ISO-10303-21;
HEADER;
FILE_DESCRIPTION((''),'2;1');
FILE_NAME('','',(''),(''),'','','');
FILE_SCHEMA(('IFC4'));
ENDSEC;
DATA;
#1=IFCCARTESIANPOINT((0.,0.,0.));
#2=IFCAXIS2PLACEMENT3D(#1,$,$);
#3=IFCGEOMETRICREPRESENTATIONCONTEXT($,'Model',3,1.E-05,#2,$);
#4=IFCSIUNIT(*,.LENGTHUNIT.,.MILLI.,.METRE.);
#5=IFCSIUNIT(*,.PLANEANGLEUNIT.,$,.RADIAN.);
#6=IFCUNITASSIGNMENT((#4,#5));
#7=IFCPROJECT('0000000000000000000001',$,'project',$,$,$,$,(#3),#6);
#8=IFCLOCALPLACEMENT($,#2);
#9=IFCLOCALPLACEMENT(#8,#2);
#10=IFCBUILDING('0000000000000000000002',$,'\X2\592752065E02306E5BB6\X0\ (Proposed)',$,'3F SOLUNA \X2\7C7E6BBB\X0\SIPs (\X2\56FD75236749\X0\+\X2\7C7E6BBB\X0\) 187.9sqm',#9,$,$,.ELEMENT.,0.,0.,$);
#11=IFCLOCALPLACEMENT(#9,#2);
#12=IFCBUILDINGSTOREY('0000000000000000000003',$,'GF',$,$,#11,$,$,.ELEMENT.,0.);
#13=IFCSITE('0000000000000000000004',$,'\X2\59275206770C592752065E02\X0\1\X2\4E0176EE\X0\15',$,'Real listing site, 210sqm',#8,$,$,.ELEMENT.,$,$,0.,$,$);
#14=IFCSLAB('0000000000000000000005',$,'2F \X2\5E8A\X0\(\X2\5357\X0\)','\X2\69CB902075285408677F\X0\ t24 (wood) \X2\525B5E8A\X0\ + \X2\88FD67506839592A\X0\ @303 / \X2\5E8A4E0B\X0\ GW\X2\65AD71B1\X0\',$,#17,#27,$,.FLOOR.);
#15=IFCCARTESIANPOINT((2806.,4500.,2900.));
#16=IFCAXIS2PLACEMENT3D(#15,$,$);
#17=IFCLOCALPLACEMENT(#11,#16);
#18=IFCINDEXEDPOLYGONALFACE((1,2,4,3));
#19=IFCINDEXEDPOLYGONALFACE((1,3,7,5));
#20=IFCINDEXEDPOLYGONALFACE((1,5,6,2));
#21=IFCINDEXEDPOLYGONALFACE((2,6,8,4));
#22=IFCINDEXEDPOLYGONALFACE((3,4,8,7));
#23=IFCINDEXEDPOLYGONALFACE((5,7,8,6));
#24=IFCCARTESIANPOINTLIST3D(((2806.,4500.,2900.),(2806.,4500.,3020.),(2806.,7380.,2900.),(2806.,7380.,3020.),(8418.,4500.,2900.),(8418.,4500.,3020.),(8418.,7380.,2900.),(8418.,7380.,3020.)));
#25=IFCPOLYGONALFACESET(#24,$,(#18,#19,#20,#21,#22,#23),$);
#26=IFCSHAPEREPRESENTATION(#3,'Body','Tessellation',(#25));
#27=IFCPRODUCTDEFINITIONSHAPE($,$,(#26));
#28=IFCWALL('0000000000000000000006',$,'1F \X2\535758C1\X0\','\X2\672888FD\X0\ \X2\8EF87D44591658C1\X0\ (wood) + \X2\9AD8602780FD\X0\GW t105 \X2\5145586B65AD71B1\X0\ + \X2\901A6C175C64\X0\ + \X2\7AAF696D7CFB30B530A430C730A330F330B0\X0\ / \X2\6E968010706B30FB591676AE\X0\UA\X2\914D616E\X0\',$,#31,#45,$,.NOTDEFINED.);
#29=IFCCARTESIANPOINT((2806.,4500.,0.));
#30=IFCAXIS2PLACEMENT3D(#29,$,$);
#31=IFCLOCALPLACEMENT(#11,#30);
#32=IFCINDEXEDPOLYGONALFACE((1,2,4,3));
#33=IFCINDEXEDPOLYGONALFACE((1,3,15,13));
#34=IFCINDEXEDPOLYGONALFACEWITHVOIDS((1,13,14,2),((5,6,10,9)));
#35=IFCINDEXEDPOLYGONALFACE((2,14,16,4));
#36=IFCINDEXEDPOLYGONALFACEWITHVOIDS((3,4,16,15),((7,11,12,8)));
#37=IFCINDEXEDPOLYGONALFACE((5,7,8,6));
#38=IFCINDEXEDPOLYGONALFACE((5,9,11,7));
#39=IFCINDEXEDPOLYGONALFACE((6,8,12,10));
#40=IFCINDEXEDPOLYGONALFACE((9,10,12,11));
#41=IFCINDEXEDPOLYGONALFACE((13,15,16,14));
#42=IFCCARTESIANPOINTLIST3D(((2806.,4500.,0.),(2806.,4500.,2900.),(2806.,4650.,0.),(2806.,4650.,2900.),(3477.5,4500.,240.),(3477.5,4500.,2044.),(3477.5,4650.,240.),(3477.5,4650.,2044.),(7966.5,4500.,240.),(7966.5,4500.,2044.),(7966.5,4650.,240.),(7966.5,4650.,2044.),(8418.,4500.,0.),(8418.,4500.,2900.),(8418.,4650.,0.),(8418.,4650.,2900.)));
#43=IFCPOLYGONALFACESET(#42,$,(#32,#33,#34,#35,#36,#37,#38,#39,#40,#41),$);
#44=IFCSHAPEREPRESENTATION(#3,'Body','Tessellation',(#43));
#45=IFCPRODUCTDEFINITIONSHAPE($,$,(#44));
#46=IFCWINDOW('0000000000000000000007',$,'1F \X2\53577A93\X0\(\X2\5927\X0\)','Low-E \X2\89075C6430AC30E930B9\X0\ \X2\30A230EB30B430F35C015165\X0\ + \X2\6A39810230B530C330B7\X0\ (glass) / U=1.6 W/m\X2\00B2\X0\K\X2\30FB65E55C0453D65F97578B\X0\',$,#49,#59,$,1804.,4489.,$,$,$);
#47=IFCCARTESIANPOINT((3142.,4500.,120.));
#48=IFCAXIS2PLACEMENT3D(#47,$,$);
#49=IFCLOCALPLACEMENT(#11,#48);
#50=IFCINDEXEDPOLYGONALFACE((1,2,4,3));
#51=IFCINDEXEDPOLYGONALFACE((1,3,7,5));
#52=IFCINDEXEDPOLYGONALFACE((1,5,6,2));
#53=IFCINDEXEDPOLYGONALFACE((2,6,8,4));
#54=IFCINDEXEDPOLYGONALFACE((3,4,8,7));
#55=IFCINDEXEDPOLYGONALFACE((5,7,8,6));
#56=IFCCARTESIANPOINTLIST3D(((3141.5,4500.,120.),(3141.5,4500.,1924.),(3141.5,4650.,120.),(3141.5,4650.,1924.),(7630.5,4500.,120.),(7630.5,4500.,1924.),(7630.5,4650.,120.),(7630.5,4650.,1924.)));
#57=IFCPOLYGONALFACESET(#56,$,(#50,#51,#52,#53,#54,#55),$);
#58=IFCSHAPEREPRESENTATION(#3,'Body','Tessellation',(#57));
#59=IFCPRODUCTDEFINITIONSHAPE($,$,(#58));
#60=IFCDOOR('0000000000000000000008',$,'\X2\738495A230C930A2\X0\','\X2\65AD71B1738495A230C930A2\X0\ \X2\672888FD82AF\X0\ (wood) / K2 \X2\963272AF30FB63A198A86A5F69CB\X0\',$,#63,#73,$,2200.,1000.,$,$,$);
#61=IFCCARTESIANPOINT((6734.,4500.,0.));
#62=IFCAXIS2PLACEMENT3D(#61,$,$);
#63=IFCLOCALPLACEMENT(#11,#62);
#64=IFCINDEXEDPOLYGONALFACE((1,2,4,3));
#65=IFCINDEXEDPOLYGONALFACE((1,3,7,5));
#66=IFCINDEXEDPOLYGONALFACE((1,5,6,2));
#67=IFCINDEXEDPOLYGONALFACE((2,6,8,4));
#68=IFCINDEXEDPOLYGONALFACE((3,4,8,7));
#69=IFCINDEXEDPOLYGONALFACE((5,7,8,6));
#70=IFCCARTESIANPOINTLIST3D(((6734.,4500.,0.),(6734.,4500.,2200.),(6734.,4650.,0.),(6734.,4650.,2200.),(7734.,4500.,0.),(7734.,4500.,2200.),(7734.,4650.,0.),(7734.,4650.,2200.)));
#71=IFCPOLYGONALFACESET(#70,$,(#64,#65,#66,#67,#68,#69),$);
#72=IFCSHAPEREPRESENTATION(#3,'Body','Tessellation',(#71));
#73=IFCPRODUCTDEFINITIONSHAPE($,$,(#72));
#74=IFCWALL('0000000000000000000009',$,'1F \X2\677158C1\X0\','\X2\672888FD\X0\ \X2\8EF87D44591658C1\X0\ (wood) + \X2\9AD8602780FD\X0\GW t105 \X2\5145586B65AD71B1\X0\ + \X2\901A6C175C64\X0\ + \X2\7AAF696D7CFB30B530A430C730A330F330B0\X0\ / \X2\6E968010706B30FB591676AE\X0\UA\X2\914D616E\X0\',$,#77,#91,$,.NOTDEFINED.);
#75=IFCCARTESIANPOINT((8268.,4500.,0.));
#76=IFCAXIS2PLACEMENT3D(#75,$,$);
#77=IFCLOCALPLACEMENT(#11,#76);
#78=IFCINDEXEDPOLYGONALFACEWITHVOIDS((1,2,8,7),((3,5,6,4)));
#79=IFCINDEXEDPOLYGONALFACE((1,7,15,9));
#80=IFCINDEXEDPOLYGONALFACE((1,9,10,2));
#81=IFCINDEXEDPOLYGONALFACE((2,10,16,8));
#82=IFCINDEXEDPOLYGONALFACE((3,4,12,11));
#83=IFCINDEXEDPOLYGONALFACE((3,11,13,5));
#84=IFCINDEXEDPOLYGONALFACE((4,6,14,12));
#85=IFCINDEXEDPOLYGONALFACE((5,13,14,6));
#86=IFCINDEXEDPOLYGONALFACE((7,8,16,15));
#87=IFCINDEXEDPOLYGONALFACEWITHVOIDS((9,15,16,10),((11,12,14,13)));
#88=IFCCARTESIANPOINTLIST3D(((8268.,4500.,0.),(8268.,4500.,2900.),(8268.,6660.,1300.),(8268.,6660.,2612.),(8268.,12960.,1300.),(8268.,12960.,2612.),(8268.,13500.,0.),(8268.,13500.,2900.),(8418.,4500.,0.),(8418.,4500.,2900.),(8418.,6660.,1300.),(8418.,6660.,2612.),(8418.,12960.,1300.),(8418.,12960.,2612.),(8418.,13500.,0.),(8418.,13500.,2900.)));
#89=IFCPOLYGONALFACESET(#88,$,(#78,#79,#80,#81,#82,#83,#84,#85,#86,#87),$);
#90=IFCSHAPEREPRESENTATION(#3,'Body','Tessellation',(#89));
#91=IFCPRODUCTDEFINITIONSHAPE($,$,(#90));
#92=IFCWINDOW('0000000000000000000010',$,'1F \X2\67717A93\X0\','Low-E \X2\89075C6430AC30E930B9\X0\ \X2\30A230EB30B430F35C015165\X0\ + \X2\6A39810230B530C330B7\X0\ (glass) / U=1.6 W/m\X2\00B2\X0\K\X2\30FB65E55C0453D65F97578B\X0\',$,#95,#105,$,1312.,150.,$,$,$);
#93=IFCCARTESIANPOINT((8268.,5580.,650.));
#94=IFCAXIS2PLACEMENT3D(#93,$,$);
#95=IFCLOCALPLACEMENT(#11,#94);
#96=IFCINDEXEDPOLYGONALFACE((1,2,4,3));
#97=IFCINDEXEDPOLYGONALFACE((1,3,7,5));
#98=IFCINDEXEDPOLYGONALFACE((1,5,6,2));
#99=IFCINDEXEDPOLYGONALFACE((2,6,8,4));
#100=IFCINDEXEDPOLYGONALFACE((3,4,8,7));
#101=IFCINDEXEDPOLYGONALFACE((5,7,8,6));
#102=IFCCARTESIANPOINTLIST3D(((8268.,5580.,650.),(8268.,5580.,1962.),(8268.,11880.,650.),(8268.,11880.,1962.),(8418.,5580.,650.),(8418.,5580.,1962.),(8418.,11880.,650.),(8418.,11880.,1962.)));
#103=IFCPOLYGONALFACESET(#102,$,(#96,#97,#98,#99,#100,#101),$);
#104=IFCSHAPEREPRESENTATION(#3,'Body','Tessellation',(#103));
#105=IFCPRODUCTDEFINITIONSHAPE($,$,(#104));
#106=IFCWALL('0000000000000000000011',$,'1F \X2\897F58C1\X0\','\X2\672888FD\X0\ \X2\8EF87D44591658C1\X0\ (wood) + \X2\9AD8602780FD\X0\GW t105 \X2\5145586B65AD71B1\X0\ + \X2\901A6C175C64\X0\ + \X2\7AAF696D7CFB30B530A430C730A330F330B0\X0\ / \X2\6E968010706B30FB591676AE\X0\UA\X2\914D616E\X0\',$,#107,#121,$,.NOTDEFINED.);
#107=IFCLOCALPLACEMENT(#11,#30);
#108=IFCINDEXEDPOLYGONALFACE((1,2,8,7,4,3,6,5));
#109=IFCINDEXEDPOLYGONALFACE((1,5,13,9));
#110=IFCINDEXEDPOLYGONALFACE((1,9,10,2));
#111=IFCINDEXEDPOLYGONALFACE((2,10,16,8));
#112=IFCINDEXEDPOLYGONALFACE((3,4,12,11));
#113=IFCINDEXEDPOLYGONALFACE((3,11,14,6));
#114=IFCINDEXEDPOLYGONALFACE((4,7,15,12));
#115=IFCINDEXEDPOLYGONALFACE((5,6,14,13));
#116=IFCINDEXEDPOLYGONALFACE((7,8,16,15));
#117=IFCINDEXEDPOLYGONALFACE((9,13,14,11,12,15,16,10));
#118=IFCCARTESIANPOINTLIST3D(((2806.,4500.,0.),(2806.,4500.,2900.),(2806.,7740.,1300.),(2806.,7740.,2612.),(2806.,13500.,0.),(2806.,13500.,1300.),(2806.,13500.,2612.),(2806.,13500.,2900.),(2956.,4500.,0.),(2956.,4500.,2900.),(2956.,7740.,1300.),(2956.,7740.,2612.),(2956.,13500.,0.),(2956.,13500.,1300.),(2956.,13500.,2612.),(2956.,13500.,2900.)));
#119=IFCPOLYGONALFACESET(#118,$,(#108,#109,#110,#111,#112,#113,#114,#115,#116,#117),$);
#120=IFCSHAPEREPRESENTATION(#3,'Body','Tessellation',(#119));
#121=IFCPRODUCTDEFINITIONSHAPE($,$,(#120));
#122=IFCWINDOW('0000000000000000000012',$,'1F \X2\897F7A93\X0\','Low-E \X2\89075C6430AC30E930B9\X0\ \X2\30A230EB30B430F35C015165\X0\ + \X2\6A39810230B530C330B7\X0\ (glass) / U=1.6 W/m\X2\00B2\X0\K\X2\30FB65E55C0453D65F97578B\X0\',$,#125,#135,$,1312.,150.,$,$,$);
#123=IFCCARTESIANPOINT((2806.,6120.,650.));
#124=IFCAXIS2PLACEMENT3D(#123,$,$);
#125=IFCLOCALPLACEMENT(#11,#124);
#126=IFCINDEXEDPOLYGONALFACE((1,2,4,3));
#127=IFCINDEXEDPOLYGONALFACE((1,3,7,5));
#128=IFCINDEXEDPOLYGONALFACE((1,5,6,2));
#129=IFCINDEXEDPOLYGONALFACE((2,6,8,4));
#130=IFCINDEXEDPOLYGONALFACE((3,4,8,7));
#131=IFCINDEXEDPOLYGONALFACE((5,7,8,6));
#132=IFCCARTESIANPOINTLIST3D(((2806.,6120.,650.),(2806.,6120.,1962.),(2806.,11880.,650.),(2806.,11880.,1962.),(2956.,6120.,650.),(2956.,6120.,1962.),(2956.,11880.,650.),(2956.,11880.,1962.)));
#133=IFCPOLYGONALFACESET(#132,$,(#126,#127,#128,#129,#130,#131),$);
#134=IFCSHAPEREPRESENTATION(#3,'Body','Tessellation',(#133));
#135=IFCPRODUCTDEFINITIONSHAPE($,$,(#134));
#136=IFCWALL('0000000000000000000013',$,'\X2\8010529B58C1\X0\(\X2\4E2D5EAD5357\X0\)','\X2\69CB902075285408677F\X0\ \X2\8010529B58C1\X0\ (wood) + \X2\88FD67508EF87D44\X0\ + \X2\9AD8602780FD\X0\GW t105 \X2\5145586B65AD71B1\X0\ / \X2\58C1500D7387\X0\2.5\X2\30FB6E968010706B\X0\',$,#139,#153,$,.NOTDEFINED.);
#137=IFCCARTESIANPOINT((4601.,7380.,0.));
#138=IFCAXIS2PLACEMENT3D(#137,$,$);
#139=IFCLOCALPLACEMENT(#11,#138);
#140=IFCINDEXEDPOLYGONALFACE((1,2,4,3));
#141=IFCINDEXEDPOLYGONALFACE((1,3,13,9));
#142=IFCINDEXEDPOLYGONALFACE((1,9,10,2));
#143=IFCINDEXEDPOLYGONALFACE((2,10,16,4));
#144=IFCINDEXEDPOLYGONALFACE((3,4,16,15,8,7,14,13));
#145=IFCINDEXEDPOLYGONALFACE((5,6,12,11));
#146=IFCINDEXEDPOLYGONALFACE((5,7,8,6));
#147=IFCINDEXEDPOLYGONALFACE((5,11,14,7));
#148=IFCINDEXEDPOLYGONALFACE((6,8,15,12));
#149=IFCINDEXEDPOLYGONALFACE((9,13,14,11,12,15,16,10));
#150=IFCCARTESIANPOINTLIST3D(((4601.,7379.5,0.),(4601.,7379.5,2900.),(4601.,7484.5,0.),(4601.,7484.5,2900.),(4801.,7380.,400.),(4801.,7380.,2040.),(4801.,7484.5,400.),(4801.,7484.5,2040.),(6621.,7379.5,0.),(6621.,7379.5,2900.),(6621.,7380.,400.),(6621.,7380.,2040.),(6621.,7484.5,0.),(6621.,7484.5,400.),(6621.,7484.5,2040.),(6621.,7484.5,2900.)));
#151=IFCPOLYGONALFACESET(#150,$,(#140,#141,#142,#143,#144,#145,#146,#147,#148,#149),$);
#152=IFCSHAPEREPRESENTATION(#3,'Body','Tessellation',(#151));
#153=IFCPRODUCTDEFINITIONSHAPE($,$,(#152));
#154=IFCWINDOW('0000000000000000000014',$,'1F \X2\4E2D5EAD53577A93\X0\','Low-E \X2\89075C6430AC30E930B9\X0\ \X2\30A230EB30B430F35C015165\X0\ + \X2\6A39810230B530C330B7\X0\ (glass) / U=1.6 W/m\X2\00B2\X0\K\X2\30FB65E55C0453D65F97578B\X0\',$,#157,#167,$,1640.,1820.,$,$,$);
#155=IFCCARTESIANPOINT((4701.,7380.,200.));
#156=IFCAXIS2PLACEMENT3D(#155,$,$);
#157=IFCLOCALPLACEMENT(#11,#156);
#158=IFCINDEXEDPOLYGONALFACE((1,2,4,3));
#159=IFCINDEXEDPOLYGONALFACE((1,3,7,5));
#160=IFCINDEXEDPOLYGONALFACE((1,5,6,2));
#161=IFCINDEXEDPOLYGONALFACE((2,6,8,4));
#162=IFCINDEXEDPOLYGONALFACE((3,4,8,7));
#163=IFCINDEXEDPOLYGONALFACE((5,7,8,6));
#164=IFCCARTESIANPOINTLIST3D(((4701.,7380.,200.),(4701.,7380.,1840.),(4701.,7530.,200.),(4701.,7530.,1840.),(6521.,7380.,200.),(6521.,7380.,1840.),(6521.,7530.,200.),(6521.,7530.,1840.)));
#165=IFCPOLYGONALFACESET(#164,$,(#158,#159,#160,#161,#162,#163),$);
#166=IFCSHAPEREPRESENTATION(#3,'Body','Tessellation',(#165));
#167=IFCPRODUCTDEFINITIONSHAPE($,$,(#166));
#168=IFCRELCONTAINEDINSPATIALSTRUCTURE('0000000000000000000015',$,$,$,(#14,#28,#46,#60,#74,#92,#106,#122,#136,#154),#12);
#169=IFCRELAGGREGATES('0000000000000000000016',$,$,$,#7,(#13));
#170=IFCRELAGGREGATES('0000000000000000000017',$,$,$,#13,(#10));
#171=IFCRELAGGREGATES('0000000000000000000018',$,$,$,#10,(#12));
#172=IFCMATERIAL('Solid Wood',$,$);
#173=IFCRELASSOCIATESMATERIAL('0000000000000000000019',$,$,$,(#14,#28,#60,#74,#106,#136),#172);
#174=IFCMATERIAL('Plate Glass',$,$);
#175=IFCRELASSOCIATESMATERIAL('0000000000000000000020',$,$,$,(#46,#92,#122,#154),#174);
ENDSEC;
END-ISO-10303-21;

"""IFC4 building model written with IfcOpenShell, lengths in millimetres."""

from ifc_helpers import new_model, si_unit, frame, frame_2d, origin, place, context, project, spatial, rectangle, extrude, material, element, fill, save


model = new_model("IFC4")

# Units and contexts
model_context = context("Model", 3, precision=1e-05, world=origin())
ifc_project = project(units=[si_unit("LENGTHUNIT", "METRE", prefix="MILLI"), si_unit("PLANEANGLEUNIT", "RADIAN")], contexts=[model_context])

# Site, building, storey
site_placement = place(None, origin())
site = spatial("IfcSite", under=ifc_project, at=site_placement, Name="大分県大分市1丁目15", ObjectType="Real listing site, 210sqm", CompositionType="ELEMENT", RefElevation=0.0)
building_placement = place(site_placement, origin())
building = spatial("IfcBuilding", under=site, at=building_placement, Name="大分市の家 (Proposed)", ObjectType="3F SOLUNA 籾殻SIPs (国産杉+籾殻) 187.9sqm", CompositionType="ELEMENT", ElevationOfRefHeight=0.0, ElevationOfTerrain=0.0)
storey_placement = place(building_placement, origin())
storey = spatial("IfcBuildingStorey", under=building, at=storey_placement, Name="GF", CompositionType="ELEMENT", Elevation=0.0)

# Slab
ifc_material_1 = material(Name="Solid Wood")
slab_1_placement = place(storey_placement, frame((2806.0, 4500.0, 2900.0)))
element("IfcSlab", 1, at=slab_1_placement, inside=storey, material=ifc_material_1, Name="2F 床(南)", Description="構造用合板 t24 (wood) 剛床 + 製材根太 @303 / 床下 GW断熱", PredefinedType="FLOOR", context=model_context, shape_type="SweptSolid", body=[
    extrude(rectangle(XDim=5612.0, YDim=2880.0, at=frame_2d((2806.0, 1440.0))), frame((2806.0, 4500.0, 2900.0)), (0.0, 0.0, 1.0), 120.0),
])

# Wall, openings, window, door
wall_1_placement = place(storey_placement, frame((2806.0, 4500.0, 0.0)))
wall_1 = element("IfcWall", 2, at=wall_1_placement, inside=storey, material=ifc_material_1, Name="1F 南壁", Description="木製 軸組外壁 (wood) + 高性能GW t105 充填断熱 + 通気層 + 窯業系サイディング / 準耐火・外皮UA配慮", PredefinedType="NOTDEFINED", context=model_context, shape_type="SweptSolid", body=[
    extrude(rectangle(XDim=5612.0, YDim=150.0, at=frame_2d((2806.0, 75.0))), frame((2806.0, 4500.0, 0.0)), (0.0, 0.0, 1.0), 2900.0),
])
opening_1_placement = place(storey_placement, frame((3142.0, 4500.0, 120.0)))
opening_1 = element("IfcOpeningElement", 3, at=opening_1_placement, cuts=wall_1, PredefinedType="NOTDEFINED", context=model_context, shape_type="SweptSolid", body=[
    extrude(rectangle(XDim=4489.0, YDim=150.0, at=frame_2d((2244.0, 75.0))), frame((3142.0, 4500.0, 120.0)), (0.0, 0.0, 1.0), 1804.0),
])
opening_2_placement = place(storey_placement, frame((6734.0, 4500.0, 0.0)))
opening_2 = element("IfcOpeningElement", 4, at=opening_2_placement, cuts=wall_1, PredefinedType="NOTDEFINED", context=model_context, shape_type="SweptSolid", body=[
    extrude(rectangle(XDim=1000.0, YDim=150.0, at=frame_2d((500.0, 75.0))), frame((6734.0, 4500.0, 0.0)), (0.0, 0.0, 1.0), 2200.0),
])
ifc_material_2 = material(Name="Plate Glass")
window_1_placement = place(storey_placement, frame((3142.0, 4500.0, 120.0)))
window_1 = element("IfcWindow", 5, at=window_1_placement, inside=storey, material=ifc_material_2, Name="1F 南窓(大)", Description="Low-E 複層ガラス アルゴン封入 + 樹脂サッシ (glass) / U=1.6 W/m²K・日射取得型", OverallHeight=1804.0, OverallWidth=4489.0, context=model_context, shape_type="SweptSolid", body=[
    extrude(rectangle(XDim=4489.0, YDim=150.0, at=frame_2d((2244.0, 75.0))), frame((3142.0, 4500.0, 120.0)), (0.0, 0.0, 1.0), 1804.0),
])
fill(opening_1, window_1)
door_placement = place(storey_placement, frame((6734.0, 4500.0, 0.0)))
door = element("IfcDoor", 6, at=door_placement, inside=storey, material=ifc_material_1, Name="玄関ドア", Description="断熱玄関ドア 木製芯 (wood) / K2 防犯・採風機構", OverallHeight=2200.0, OverallWidth=1000.0, context=model_context, shape_type="SweptSolid", body=[
    extrude(rectangle(XDim=1000.0, YDim=150.0, at=frame_2d((500.0, 75.0))), frame((6734.0, 4500.0, 0.0)), (0.0, 0.0, 1.0), 2200.0),
])
fill(opening_2, door)

# Walls, openings, windows
wall_2_placement = place(storey_placement, frame((8268.0, 4500.0, 0.0)))
wall_2 = element("IfcWall", 7, at=wall_2_placement, inside=storey, material=ifc_material_1, Name="1F 東壁", Description="木製 軸組外壁 (wood) + 高性能GW t105 充填断熱 + 通気層 + 窯業系サイディング / 準耐火・外皮UA配慮", PredefinedType="NOTDEFINED", context=model_context, shape_type="SweptSolid", body=[
    extrude(rectangle(XDim=150.0, YDim=9000.0, at=frame_2d((75.0, 4500.0))), frame((8268.0, 4500.0, 0.0)), (0.0, 0.0, 1.0), 2900.0),
])
opening_3_placement = place(storey_placement, frame((8268.0, 5580.0, 650.0)))
opening_3 = element("IfcOpeningElement", 8, at=opening_3_placement, cuts=wall_2, PredefinedType="NOTDEFINED", context=model_context, shape_type="SweptSolid", body=[
    extrude(rectangle(XDim=150.0, YDim=6300.0, at=frame_2d((75.0, 3150.0))), frame((8268.0, 5580.0, 650.0)), (0.0, 0.0, 1.0), 1312.0),
])
window_2_placement = place(storey_placement, frame((8268.0, 5580.0, 650.0)))
window_2 = element("IfcWindow", 9, at=window_2_placement, inside=storey, material=ifc_material_2, Name="1F 東窓", Description="Low-E 複層ガラス アルゴン封入 + 樹脂サッシ (glass) / U=1.6 W/m²K・日射取得型", OverallHeight=1312.0, OverallWidth=150.0, context=model_context, shape_type="SweptSolid", body=[
    extrude(rectangle(XDim=150.0, YDim=6300.0, at=frame_2d((75.0, 3150.0))), frame((8268.0, 5580.0, 650.0)), (0.0, 0.0, 1.0), 1312.0),
])
fill(opening_3, window_2)
wall_3_placement = place(storey_placement, frame((2806.0, 4500.0, 0.0)))
wall_3 = element("IfcWall", 10, at=wall_3_placement, inside=storey, material=ifc_material_1, Name="1F 西壁", Description="木製 軸組外壁 (wood) + 高性能GW t105 充填断熱 + 通気層 + 窯業系サイディング / 準耐火・外皮UA配慮", PredefinedType="NOTDEFINED", context=model_context, shape_type="SweptSolid", body=[
    extrude(rectangle(XDim=150.0, YDim=9000.0, at=frame_2d((75.0, 4500.0))), frame((2806.0, 4500.0, 0.0)), (0.0, 0.0, 1.0), 2900.0),
])
opening_4_placement = place(storey_placement, frame((2806.0, 6120.0, 650.0)))
opening_4 = element("IfcOpeningElement", 11, at=opening_4_placement, cuts=wall_3, PredefinedType="NOTDEFINED", context=model_context, shape_type="SweptSolid", body=[
    extrude(rectangle(XDim=150.0, YDim=5760.0, at=frame_2d((75.0, 2880.0))), frame((2806.0, 6120.0, 650.0)), (0.0, 0.0, 1.0), 1312.0),
])
window_3_placement = place(storey_placement, frame((2806.0, 6120.0, 650.0)))
window_3 = element("IfcWindow", 12, at=window_3_placement, inside=storey, material=ifc_material_2, Name="1F 西窓", Description="Low-E 複層ガラス アルゴン封入 + 樹脂サッシ (glass) / U=1.6 W/m²K・日射取得型", OverallHeight=1312.0, OverallWidth=150.0, context=model_context, shape_type="SweptSolid", body=[
    extrude(rectangle(XDim=150.0, YDim=5760.0, at=frame_2d((75.0, 2880.0))), frame((2806.0, 6120.0, 650.0)), (0.0, 0.0, 1.0), 1312.0),
])
fill(opening_4, window_3)
wall_4_placement = place(storey_placement, frame((4601.0, 7380.0, 0.0)))
wall_4 = element("IfcWall", 13, at=wall_4_placement, inside=storey, material=ifc_material_1, Name="耐力壁(中庭南)", Description="構造用合板 耐力壁 (wood) + 製材軸組 + 高性能GW t105 充填断熱 / 壁倍率2.5・準耐火", PredefinedType="NOTDEFINED", context=model_context, shape_type="SweptSolid", body=[
    extrude(rectangle(XDim=2020.0, YDim=105.0, at=frame_2d((1010.0, 52.0))), frame((4601.0, 7380.0, 0.0)), (0.0, 0.0, 1.0), 2900.0),
])
opening_5_placement = place(storey_placement, frame((4701.0, 7380.0, 200.0)))
opening_5 = element("IfcOpeningElement", 14, at=opening_5_placement, cuts=wall_4, PredefinedType="NOTDEFINED", context=model_context, shape_type="SweptSolid", body=[
    extrude(rectangle(XDim=1820.0, YDim=150.0, at=frame_2d((910.0, 75.0))), frame((4701.0, 7380.0, 200.0)), (0.0, 0.0, 1.0), 1640.0),
])
window_4_placement = place(storey_placement, frame((4701.0, 7380.0, 200.0)))
window_4 = element("IfcWindow", 15, at=window_4_placement, inside=storey, material=ifc_material_2, Name="1F 中庭南窓", Description="Low-E 複層ガラス アルゴン封入 + 樹脂サッシ (glass) / U=1.6 W/m²K・日射取得型", OverallHeight=1640.0, OverallWidth=1820.0, context=model_context, shape_type="SweptSolid", body=[
    extrude(rectangle(XDim=1820.0, YDim=150.0, at=frame_2d((910.0, 75.0))), frame((4701.0, 7380.0, 200.0)), (0.0, 0.0, 1.0), 1640.0),
])
fill(opening_5, window_4)

save(model, "model.ifc")
